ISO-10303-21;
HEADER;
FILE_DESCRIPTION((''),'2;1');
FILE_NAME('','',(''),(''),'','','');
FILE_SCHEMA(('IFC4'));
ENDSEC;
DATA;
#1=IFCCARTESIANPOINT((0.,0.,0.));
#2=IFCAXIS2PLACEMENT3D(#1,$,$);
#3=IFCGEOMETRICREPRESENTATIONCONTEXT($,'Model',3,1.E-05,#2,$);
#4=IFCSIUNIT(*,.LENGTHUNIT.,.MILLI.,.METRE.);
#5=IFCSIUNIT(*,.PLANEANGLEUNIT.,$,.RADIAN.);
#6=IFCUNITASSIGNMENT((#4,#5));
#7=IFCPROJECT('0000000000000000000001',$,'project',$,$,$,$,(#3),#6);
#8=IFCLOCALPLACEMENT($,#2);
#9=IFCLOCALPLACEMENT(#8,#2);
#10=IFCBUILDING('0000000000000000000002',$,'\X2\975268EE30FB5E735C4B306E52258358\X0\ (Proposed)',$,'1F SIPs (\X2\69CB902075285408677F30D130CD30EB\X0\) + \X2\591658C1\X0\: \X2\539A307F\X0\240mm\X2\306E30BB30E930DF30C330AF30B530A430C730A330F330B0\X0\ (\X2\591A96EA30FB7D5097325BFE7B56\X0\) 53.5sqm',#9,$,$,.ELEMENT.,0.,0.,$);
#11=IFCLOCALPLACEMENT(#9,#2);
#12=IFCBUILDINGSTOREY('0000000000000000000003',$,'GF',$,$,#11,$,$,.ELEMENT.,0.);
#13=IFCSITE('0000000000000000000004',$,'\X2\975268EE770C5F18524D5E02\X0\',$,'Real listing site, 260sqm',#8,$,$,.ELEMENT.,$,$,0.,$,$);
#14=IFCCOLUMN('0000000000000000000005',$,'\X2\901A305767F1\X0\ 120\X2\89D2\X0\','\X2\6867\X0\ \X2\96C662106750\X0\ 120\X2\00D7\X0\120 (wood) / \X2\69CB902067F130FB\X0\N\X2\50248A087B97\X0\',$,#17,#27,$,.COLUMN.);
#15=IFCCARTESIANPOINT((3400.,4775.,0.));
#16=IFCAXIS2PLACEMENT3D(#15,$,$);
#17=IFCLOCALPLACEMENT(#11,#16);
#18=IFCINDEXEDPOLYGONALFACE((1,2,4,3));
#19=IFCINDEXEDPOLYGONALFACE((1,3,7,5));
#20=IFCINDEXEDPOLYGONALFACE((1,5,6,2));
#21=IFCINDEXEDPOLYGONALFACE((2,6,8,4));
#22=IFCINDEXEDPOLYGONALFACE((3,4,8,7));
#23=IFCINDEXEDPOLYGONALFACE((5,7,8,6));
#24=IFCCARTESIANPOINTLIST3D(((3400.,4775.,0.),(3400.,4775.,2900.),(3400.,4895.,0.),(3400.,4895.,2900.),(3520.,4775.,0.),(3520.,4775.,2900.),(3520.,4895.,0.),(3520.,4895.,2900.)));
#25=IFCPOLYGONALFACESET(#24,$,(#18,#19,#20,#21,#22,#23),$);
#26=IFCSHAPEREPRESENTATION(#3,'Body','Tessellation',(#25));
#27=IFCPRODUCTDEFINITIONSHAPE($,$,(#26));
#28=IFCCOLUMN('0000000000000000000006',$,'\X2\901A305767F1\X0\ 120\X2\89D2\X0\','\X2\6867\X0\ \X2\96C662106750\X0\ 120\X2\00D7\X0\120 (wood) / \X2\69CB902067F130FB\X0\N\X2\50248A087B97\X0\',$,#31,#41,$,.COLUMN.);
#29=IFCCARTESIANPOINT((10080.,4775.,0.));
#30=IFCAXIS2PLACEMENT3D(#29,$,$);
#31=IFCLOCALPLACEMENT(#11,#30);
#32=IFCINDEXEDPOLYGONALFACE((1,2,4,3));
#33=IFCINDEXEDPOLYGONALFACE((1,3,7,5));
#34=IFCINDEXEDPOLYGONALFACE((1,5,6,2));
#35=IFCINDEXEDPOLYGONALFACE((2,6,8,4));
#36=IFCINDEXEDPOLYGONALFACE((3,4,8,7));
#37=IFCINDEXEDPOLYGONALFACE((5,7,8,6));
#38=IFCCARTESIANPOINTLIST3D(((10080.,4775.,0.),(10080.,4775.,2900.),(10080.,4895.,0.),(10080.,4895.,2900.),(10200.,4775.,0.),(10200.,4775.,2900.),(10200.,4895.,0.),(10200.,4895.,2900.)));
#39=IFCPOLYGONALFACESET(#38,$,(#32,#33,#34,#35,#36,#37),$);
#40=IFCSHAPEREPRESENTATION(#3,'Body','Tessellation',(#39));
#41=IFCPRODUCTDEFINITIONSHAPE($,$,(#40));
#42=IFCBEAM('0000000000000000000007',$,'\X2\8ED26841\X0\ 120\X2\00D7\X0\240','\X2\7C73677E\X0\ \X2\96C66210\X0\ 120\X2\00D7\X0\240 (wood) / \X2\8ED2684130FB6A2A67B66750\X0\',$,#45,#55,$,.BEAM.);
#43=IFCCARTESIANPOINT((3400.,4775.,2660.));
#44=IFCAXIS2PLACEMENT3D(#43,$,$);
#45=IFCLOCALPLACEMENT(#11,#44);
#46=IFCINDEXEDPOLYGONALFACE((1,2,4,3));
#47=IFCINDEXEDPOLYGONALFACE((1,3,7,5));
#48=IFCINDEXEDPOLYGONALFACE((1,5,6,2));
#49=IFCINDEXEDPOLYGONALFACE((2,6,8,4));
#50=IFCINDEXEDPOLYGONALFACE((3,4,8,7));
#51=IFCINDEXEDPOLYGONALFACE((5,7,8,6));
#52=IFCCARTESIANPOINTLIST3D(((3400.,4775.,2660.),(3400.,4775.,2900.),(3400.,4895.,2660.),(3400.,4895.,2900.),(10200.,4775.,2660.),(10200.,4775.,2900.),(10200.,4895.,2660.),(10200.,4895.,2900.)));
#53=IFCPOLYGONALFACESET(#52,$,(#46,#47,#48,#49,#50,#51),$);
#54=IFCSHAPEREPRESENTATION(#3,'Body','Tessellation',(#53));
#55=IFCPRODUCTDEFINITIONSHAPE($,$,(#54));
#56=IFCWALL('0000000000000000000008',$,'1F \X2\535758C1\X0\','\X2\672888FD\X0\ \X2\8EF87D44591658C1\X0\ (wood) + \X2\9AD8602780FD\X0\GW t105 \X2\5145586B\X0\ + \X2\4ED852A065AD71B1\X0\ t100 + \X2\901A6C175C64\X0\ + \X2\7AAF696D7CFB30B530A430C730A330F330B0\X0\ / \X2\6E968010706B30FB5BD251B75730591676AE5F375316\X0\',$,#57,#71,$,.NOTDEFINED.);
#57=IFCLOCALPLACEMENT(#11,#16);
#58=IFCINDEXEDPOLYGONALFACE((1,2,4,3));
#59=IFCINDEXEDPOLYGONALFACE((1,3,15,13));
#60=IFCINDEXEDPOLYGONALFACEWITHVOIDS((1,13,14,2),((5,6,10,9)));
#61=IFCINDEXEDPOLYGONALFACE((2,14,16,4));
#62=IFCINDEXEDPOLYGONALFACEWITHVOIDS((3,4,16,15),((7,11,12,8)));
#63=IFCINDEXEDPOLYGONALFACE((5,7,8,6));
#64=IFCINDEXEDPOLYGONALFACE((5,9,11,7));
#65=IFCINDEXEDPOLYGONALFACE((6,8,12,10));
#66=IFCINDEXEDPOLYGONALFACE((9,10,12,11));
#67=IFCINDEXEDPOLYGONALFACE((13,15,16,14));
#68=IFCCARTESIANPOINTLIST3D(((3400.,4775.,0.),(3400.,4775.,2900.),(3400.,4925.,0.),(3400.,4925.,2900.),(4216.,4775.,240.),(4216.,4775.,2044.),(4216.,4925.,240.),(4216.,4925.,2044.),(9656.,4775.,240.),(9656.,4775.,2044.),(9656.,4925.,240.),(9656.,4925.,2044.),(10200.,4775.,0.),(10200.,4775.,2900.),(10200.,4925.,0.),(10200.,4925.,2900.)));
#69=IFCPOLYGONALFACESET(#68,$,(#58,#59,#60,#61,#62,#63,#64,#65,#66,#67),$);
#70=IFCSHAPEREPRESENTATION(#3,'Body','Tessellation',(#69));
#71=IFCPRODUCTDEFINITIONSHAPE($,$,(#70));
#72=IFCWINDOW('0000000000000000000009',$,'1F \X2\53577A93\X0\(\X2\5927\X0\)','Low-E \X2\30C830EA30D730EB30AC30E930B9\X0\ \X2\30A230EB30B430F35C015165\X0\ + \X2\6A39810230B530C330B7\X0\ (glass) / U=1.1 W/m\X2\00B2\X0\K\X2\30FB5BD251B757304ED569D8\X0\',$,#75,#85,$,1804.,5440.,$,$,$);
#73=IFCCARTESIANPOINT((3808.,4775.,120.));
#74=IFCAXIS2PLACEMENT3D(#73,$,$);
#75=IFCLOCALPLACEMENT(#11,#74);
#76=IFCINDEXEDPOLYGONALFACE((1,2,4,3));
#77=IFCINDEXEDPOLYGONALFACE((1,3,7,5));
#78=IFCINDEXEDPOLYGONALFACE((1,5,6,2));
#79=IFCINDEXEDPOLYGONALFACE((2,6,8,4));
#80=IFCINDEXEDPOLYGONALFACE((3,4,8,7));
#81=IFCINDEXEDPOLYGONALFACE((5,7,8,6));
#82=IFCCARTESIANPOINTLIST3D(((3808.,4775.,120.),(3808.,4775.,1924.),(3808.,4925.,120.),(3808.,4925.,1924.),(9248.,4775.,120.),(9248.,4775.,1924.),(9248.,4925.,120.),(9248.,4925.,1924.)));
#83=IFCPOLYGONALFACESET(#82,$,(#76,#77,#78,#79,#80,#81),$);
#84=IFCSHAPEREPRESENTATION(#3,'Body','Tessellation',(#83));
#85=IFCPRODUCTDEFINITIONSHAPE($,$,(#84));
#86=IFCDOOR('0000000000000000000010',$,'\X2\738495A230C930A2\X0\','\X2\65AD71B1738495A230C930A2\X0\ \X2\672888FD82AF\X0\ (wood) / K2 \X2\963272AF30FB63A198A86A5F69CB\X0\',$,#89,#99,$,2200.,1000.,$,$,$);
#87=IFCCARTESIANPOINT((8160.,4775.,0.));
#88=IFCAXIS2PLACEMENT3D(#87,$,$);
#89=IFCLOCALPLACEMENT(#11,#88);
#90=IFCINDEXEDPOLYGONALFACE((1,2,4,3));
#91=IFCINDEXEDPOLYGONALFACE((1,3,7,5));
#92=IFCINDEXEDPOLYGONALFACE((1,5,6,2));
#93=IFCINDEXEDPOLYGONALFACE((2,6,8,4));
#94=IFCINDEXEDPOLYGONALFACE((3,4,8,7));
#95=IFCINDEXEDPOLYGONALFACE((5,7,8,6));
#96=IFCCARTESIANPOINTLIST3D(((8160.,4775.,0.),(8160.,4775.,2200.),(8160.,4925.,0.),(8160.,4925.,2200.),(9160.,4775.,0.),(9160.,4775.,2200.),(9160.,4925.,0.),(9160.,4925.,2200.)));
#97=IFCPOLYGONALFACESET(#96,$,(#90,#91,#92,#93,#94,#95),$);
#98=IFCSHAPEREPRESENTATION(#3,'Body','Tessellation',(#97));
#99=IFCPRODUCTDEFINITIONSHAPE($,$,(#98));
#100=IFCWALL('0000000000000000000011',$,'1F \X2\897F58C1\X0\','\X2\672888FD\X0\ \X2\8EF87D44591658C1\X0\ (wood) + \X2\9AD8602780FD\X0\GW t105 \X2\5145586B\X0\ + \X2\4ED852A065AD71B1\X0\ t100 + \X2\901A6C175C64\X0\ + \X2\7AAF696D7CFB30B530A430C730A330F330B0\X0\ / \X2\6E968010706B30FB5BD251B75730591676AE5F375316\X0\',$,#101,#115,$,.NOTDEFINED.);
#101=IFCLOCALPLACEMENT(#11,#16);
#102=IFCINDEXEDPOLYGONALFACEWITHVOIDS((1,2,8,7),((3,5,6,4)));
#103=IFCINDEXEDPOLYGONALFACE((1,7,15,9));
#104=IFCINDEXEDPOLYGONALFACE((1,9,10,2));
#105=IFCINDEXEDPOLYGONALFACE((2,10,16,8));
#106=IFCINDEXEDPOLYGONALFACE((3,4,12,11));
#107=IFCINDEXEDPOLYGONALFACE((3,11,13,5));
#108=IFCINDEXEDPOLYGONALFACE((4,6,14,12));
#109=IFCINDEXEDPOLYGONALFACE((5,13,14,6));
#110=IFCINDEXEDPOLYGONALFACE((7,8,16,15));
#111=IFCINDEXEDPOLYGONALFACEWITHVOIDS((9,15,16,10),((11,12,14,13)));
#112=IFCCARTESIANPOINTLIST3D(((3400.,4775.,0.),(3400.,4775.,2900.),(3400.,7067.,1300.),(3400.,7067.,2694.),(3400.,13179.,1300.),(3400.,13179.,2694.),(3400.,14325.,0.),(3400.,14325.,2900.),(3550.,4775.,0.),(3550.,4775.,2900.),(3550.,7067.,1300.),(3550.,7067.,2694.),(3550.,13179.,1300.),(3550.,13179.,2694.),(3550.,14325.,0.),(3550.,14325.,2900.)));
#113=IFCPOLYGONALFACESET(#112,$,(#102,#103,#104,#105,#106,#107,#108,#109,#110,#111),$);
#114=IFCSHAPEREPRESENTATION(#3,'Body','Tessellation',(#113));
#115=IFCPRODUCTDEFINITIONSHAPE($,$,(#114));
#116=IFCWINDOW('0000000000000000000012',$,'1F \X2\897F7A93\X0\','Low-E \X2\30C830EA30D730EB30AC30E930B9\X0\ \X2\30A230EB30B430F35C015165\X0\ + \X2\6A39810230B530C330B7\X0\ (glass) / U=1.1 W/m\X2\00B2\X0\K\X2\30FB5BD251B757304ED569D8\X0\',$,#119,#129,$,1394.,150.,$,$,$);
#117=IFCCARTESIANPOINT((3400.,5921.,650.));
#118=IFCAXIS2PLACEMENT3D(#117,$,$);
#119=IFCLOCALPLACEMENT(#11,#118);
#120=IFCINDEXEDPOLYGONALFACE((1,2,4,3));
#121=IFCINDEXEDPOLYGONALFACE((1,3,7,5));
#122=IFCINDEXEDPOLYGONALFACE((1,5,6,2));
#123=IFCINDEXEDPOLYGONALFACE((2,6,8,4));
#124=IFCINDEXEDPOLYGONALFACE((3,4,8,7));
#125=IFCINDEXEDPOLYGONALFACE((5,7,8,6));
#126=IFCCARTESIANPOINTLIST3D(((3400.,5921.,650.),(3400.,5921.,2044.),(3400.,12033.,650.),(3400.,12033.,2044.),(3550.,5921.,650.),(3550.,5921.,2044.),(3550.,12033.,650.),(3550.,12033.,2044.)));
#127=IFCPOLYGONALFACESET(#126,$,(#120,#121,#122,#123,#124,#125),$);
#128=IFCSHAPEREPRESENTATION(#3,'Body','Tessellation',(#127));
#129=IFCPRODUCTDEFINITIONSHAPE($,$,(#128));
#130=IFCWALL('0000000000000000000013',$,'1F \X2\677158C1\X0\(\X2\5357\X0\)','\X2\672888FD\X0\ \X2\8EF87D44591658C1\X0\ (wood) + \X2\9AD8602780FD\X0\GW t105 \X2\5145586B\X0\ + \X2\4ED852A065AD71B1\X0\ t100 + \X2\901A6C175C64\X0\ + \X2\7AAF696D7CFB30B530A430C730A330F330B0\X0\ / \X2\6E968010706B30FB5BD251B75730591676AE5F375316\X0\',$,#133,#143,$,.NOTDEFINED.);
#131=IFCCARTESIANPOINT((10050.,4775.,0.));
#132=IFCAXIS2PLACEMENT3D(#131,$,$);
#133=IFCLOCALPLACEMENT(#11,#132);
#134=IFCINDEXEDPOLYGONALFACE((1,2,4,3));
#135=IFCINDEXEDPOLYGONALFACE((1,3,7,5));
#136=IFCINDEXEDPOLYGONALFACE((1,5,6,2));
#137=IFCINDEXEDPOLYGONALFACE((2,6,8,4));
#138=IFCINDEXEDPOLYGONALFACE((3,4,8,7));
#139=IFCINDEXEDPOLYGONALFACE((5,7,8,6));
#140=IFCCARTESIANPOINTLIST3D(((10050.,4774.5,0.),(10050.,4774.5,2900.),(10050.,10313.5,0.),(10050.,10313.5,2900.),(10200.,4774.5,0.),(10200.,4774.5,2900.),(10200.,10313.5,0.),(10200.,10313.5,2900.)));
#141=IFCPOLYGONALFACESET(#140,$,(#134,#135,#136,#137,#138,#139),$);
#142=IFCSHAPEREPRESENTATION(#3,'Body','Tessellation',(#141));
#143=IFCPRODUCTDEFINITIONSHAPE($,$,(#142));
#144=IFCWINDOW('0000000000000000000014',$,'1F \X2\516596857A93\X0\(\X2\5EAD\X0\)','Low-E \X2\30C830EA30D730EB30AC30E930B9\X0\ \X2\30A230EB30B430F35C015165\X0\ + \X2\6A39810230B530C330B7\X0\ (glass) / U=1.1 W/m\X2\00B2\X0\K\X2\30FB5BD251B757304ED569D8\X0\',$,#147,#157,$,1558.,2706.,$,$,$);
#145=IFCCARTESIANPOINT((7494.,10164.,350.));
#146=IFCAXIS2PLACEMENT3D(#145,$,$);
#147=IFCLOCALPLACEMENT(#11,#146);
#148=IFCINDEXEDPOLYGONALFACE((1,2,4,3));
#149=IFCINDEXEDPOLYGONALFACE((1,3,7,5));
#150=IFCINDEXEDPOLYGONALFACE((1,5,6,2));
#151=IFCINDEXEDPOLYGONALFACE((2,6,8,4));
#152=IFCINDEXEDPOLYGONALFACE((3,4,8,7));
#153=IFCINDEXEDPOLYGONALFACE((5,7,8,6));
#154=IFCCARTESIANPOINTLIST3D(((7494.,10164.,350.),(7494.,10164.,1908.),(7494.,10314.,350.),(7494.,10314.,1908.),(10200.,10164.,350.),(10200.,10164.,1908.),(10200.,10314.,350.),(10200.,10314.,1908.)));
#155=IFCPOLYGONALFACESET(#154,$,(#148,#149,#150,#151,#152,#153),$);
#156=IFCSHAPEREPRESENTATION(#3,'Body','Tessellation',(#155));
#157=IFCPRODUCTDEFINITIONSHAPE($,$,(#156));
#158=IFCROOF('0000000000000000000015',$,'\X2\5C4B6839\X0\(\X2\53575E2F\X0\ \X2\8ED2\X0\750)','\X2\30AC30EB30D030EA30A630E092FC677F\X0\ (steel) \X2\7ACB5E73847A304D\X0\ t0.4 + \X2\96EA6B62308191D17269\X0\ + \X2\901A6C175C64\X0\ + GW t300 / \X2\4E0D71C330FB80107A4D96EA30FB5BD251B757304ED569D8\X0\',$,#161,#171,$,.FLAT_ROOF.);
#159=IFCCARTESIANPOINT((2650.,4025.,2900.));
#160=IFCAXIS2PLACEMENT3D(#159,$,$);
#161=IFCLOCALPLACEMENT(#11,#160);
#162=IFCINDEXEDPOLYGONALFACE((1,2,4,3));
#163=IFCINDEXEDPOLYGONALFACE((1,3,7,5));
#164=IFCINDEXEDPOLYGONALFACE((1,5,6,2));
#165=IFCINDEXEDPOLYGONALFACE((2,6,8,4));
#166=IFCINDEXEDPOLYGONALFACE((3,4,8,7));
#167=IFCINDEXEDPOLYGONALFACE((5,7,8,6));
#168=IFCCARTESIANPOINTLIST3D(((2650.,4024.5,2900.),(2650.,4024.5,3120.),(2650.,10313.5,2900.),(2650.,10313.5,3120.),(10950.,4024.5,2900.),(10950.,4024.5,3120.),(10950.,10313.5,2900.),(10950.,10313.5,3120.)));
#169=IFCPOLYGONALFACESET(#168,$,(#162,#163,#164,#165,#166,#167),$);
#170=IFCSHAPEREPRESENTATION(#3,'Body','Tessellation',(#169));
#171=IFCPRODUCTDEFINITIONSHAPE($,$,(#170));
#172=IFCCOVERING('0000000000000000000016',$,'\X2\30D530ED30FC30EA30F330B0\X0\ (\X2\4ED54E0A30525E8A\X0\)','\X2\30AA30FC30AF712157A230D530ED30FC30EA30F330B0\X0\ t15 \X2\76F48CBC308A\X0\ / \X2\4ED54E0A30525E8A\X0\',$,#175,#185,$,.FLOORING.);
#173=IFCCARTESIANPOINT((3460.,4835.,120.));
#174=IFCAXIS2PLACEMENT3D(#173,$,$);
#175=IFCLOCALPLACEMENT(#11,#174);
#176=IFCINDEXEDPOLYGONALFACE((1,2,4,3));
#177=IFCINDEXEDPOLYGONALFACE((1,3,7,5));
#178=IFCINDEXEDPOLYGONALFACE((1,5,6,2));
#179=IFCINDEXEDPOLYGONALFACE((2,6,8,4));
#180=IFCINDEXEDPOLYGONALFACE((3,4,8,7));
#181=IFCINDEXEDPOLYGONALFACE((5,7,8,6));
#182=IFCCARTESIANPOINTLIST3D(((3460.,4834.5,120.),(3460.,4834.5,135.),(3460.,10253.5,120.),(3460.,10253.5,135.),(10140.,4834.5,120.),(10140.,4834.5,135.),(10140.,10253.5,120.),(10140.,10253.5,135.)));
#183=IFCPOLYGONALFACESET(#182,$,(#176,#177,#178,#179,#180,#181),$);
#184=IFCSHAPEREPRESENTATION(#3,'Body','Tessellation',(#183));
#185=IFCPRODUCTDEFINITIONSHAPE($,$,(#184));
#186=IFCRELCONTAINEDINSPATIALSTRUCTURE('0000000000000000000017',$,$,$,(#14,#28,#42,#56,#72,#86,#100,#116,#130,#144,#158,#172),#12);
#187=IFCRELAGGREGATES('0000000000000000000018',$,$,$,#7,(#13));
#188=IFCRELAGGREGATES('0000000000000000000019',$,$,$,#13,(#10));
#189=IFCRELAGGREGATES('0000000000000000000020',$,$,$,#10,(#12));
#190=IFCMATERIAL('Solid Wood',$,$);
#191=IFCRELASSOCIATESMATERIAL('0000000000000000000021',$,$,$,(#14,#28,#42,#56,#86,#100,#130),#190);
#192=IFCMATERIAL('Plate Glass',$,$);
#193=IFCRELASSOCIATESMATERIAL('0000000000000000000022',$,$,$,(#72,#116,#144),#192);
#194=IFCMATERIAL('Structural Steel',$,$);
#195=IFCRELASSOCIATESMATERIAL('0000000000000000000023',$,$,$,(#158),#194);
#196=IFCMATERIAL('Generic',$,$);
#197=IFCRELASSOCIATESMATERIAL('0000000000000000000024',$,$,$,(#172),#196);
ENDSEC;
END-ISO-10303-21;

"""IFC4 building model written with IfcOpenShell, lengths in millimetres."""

from ifc_helpers import new_model, si_unit, frame, frame_2d, origin, place, context, project, spatial, rectangle, extrude, material, element, fill, save


model = new_model("IFC4")

# Units and contexts
model_context = context("Model", 3, precision=1e-05, world=origin())
ifc_project = project(units=[si_unit("LENGTHUNIT", "METRE", prefix="MILLI"), si_unit("PLANEANGLEUNIT", "RADIAN")], contexts=[model_context])

# Site, building, storey
site_placement = place(None, origin())
site = spatial("IfcSite", under=ifc_project, at=site_placement, Name="青森県弘前市", ObjectType="Real listing site, 260sqm", CompositionType="ELEMENT", RefElevation=0.0)
building_placement = place(site_placement, origin())
building = spatial("IfcBuilding", under=site, at=building_placement, Name="青森・平屋の別荘 (Proposed)", ObjectType="1F SIPs (構造用合板パネル) + 外壁: 厚み240mmのセラミックサイディング (多雪・結露対策) 53.5sqm", CompositionType="ELEMENT", ElevationOfRefHeight=0.0, ElevationOfTerrain=0.0)
storey_placement = place(building_placement, origin())
storey = spatial("IfcBuildingStorey", under=building, at=storey_placement, Name="GF", CompositionType="ELEMENT", Elevation=0.0)

# Columns
ifc_material_1 = material(Name="Solid Wood")
column_1_placement = place(storey_placement, frame((3400.0, 4775.0, 0.0)))
element("IfcColumn", 1, at=column_1_placement, inside=storey, material=ifc_material_1, Name="通し柱 120角", Description="桧 集成材 120×120 (wood) / 構造柱・N値計算", PredefinedType="COLUMN", context=model_context, shape_type="SweptSolid", body=[
    extrude(rectangle(XDim=120.0, YDim=120.0, at=frame_2d((60.0, 60.0))), frame((3400.0, 4775.0, 0.0)), (0.0, 0.0, 1.0), 2900.0),
])
column_2_placement = place(storey_placement, frame((10080.0, 4775.0, 0.0)))
element("IfcColumn", 2, at=column_2_placement, inside=storey, material=ifc_material_1, Name="通し柱 120角", Description="桧 集成材 120×120 (wood) / 構造柱・N値計算", PredefinedType="COLUMN", context=model_context, shape_type="SweptSolid", body=[
    extrude(rectangle(XDim=120.0, YDim=120.0, at=frame_2d((60.0, 60.0))), frame((10080.0, 4775.0, 0.0)), (0.0, 0.0, 1.0), 2900.0),
])

# Beam
beam_1_placement = place(storey_placement, frame((3400.0, 4775.0, 2660.0)))
element("IfcBeam", 3, at=beam_1_placement, inside=storey, material=ifc_material_1, Name="軒桁 120×240", Description="米松 集成 120×240 (wood) / 軒桁・横架材", PredefinedType="BEAM", context=model_context, shape_type="SweptSolid", body=[
    extrude(rectangle(XDim=6800.0, YDim=120.0, at=frame_2d((3400.0, 60.0))), frame((3400.0, 4775.0, 2660.0)), (0.0, 0.0, 1.0), 240.0),
])

# Wall, openings, window, door
wall_1_placement = place(storey_placement, frame((3400.0, 4775.0, 0.0)))
wall_1 = element("IfcWall", 4, at=wall_1_placement, inside=storey, material=ifc_material_1, Name="1F 南壁", Description="木製 軸組外壁 (wood) + 高性能GW t105 充填 + 付加断熱 t100 + 通気層 + 窯業系サイディング / 準耐火・寒冷地外皮強化", PredefinedType="NOTDEFINED", context=model_context, shape_type="SweptSolid", body=[
    extrude(rectangle(XDim=6800.0, YDim=150.0, at=frame_2d((3400.0, 75.0))), frame((3400.0, 4775.0, 0.0)), (0.0, 0.0, 1.0), 2900.0),
])
opening_1_placement = place(storey_placement, frame((3808.0, 4775.0, 120.0)))
opening_1 = element("IfcOpeningElement", 5, at=opening_1_placement, cuts=wall_1, PredefinedType="NOTDEFINED", context=model_context, shape_type="SweptSolid", body=[
    extrude(rectangle(XDim=5440.0, YDim=150.0, at=frame_2d((2720.0, 75.0))), frame((3808.0, 4775.0, 120.0)), (0.0, 0.0, 1.0), 1804.0),
])
opening_2_placement = place(storey_placement, frame((8160.0, 4775.0, 0.0)))
opening_2 = element("IfcOpeningElement", 6, at=opening_2_placement, cuts=wall_1, PredefinedType="NOTDEFINED", context=model_context, shape_type="SweptSolid", body=[
    extrude(rectangle(XDim=1000.0, YDim=150.0, at=frame_2d((500.0, 75.0))), frame((8160.0, 4775.0, 0.0)), (0.0, 0.0, 1.0), 2200.0),
])
ifc_material_2 = material(Name="Plate Glass")
window_1_placement = place(storey_placement, frame((3808.0, 4775.0, 120.0)))
window_1 = element("IfcWindow", 7, at=window_1_placement, inside=storey, material=ifc_material_2, Name="1F 南窓(大)", Description="Low-E トリプルガラス アルゴン封入 + 樹脂サッシ (glass) / U=1.1 W/m²K・寒冷地仕様", OverallHeight=1804.0, OverallWidth=5440.0, context=model_context, shape_type="SweptSolid", body=[
    extrude(rectangle(XDim=5440.0, YDim=150.0, at=frame_2d((2720.0, 75.0))), frame((3808.0, 4775.0, 120.0)), (0.0, 0.0, 1.0), 1804.0),
])
fill(opening_1, window_1)
door_1_placement = place(storey_placement, frame((8160.0, 4775.0, 0.0)))
door_1 = element("IfcDoor", 8, at=door_1_placement, inside=storey, material=ifc_material_1, Name="玄関ドア", Description="断熱玄関ドア 木製芯 (wood) / K2 防犯・採風機構", OverallHeight=2200.0, OverallWidth=1000.0, context=model_context, shape_type="SweptSolid", body=[
    extrude(rectangle(XDim=1000.0, YDim=150.0, at=frame_2d((500.0, 75.0))), frame((8160.0, 4775.0, 0.0)), (0.0, 0.0, 1.0), 2200.0),
])
fill(opening_2, door_1)

# Walls, openings, windows
wall_2_placement = place(storey_placement, frame((3400.0, 4775.0, 0.0)))
wall_2 = element("IfcWall", 9, at=wall_2_placement, inside=storey, material=ifc_material_1, Name="1F 西壁", Description="木製 軸組外壁 (wood) + 高性能GW t105 充填 + 付加断熱 t100 + 通気層 + 窯業系サイディング / 準耐火・寒冷地外皮強化", PredefinedType="NOTDEFINED", context=model_context, shape_type="SweptSolid", body=[
    extrude(rectangle(XDim=150.0, YDim=9550.0, at=frame_2d((75.0, 4775.0))), frame((3400.0, 4775.0, 0.0)), (0.0, 0.0, 1.0), 2900.0),
])
opening_3_placement = place(storey_placement, frame((3400.0, 5921.0, 650.0)))
opening_3 = element("IfcOpeningElement", 10, at=opening_3_placement, cuts=wall_2, PredefinedType="NOTDEFINED", context=model_context, shape_type="SweptSolid", body=[
    extrude(rectangle(XDim=150.0, YDim=6112.0, at=frame_2d((75.0, 3056.0))), frame((3400.0, 5921.0, 650.0)), (0.0, 0.0, 1.0), 1394.0),
])
window_2_placement = place(storey_placement, frame((3400.0, 5921.0, 650.0)))
window_2 = element("IfcWindow", 11, at=window_2_placement, inside=storey, material=ifc_material_2, Name="1F 西窓", Description="Low-E トリプルガラス アルゴン封入 + 樹脂サッシ (glass) / U=1.1 W/m²K・寒冷地仕様", OverallHeight=1394.0, OverallWidth=150.0, context=model_context, shape_type="SweptSolid", body=[
    extrude(rectangle(XDim=150.0, YDim=6112.0, at=frame_2d((75.0, 3056.0))), frame((3400.0, 5921.0, 650.0)), (0.0, 0.0, 1.0), 1394.0),
])
fill(opening_3, window_2)
wall_3_placement = place(storey_placement, frame((10050.0, 4775.0, 0.0)))
wall_3 = element("IfcWall", 12, at=wall_3_placement, inside=storey, material=ifc_material_1, Name="1F 東壁(南)", Description="木製 軸組外壁 (wood) + 高性能GW t105 充填 + 付加断熱 t100 + 通気層 + 窯業系サイディング / 準耐火・寒冷地外皮強化", PredefinedType="NOTDEFINED", context=model_context, shape_type="SweptSolid", body=[
    extrude(rectangle(XDim=150.0, YDim=5539.0, at=frame_2d((75.0, 2769.0))), frame((10050.0, 4775.0, 0.0)), (0.0, 0.0, 1.0), 2900.0),
])
opening_4_placement = place(storey_placement, frame((7494.0, 10164.0, 350.0)))
opening_4 = element("IfcOpeningElement", 13, at=opening_4_placement, cuts=wall_3, PredefinedType="NOTDEFINED", context=model_context, shape_type="SweptSolid", body=[
    extrude(rectangle(XDim=2706.0, YDim=150.0, at=frame_2d((1353.0, 75.0))), frame((7494.0, 10164.0, 350.0)), (0.0, 0.0, 1.0), 1558.0),
])
window_3_placement = place(storey_placement, frame((7494.0, 10164.0, 350.0)))
window_3 = element("IfcWindow", 14, at=window_3_placement, inside=storey, material=ifc_material_2, Name="1F 入隅窓(庭)", Description="Low-E トリプルガラス アルゴン封入 + 樹脂サッシ (glass) / U=1.1 W/m²K・寒冷地仕様", OverallHeight=1558.0, OverallWidth=2706.0, context=model_context, shape_type="SweptSolid", body=[
    extrude(rectangle(XDim=2706.0, YDim=150.0, at=frame_2d((1353.0, 75.0))), frame((7494.0, 10164.0, 350.0)), (0.0, 0.0, 1.0), 1558.0),
])
fill(opening_4, window_3)

# Roof
ifc_material_3 = material(Name="Structural Steel")
roof_placement = place(storey_placement, frame((2650.0, 4025.0, 2900.0)))
element("IfcRoof", 15, at=roof_placement, inside=storey, material=ifc_material_3, Name="屋根(南帯 軒750)", Description="ガルバリウム鋼板 (steel) 立平葺き t0.4 + 雪止め金物 + 通気層 + GW t300 / 不燃・耐積雪・寒冷地仕様", PredefinedType="FLAT_ROOF", context=model_context, shape_type="SweptSolid", body=[
    extrude(rectangle(XDim=8300.0, YDim=6289.0, at=frame_2d((4150.0, 3144.0))), frame((2650.0, 4025.0, 2900.0)), (0.0, 0.0, 1.0), 220.0),
])

# Covering
ifc_material_4 = material(Name="Generic")
covering_1_placement = place(storey_placement, frame((3460.0, 4835.0, 120.0)))
element("IfcCovering", 16, at=covering_1_placement, inside=storey, material=ifc_material_4, Name="フローリング (仕上げ床)", Description="オーク無垢フローリング t15 直貼り / 仕上げ床", PredefinedType="FLOORING", context=model_context, shape_type="SweptSolid", body=[
    extrude(rectangle(XDim=6680.0, YDim=5419.0, at=frame_2d((3340.0, 2709.0))), frame((3460.0, 4835.0, 120.0)), (0.0, 0.0, 1.0), 15.0),
])

save(model, "model.ifc")
